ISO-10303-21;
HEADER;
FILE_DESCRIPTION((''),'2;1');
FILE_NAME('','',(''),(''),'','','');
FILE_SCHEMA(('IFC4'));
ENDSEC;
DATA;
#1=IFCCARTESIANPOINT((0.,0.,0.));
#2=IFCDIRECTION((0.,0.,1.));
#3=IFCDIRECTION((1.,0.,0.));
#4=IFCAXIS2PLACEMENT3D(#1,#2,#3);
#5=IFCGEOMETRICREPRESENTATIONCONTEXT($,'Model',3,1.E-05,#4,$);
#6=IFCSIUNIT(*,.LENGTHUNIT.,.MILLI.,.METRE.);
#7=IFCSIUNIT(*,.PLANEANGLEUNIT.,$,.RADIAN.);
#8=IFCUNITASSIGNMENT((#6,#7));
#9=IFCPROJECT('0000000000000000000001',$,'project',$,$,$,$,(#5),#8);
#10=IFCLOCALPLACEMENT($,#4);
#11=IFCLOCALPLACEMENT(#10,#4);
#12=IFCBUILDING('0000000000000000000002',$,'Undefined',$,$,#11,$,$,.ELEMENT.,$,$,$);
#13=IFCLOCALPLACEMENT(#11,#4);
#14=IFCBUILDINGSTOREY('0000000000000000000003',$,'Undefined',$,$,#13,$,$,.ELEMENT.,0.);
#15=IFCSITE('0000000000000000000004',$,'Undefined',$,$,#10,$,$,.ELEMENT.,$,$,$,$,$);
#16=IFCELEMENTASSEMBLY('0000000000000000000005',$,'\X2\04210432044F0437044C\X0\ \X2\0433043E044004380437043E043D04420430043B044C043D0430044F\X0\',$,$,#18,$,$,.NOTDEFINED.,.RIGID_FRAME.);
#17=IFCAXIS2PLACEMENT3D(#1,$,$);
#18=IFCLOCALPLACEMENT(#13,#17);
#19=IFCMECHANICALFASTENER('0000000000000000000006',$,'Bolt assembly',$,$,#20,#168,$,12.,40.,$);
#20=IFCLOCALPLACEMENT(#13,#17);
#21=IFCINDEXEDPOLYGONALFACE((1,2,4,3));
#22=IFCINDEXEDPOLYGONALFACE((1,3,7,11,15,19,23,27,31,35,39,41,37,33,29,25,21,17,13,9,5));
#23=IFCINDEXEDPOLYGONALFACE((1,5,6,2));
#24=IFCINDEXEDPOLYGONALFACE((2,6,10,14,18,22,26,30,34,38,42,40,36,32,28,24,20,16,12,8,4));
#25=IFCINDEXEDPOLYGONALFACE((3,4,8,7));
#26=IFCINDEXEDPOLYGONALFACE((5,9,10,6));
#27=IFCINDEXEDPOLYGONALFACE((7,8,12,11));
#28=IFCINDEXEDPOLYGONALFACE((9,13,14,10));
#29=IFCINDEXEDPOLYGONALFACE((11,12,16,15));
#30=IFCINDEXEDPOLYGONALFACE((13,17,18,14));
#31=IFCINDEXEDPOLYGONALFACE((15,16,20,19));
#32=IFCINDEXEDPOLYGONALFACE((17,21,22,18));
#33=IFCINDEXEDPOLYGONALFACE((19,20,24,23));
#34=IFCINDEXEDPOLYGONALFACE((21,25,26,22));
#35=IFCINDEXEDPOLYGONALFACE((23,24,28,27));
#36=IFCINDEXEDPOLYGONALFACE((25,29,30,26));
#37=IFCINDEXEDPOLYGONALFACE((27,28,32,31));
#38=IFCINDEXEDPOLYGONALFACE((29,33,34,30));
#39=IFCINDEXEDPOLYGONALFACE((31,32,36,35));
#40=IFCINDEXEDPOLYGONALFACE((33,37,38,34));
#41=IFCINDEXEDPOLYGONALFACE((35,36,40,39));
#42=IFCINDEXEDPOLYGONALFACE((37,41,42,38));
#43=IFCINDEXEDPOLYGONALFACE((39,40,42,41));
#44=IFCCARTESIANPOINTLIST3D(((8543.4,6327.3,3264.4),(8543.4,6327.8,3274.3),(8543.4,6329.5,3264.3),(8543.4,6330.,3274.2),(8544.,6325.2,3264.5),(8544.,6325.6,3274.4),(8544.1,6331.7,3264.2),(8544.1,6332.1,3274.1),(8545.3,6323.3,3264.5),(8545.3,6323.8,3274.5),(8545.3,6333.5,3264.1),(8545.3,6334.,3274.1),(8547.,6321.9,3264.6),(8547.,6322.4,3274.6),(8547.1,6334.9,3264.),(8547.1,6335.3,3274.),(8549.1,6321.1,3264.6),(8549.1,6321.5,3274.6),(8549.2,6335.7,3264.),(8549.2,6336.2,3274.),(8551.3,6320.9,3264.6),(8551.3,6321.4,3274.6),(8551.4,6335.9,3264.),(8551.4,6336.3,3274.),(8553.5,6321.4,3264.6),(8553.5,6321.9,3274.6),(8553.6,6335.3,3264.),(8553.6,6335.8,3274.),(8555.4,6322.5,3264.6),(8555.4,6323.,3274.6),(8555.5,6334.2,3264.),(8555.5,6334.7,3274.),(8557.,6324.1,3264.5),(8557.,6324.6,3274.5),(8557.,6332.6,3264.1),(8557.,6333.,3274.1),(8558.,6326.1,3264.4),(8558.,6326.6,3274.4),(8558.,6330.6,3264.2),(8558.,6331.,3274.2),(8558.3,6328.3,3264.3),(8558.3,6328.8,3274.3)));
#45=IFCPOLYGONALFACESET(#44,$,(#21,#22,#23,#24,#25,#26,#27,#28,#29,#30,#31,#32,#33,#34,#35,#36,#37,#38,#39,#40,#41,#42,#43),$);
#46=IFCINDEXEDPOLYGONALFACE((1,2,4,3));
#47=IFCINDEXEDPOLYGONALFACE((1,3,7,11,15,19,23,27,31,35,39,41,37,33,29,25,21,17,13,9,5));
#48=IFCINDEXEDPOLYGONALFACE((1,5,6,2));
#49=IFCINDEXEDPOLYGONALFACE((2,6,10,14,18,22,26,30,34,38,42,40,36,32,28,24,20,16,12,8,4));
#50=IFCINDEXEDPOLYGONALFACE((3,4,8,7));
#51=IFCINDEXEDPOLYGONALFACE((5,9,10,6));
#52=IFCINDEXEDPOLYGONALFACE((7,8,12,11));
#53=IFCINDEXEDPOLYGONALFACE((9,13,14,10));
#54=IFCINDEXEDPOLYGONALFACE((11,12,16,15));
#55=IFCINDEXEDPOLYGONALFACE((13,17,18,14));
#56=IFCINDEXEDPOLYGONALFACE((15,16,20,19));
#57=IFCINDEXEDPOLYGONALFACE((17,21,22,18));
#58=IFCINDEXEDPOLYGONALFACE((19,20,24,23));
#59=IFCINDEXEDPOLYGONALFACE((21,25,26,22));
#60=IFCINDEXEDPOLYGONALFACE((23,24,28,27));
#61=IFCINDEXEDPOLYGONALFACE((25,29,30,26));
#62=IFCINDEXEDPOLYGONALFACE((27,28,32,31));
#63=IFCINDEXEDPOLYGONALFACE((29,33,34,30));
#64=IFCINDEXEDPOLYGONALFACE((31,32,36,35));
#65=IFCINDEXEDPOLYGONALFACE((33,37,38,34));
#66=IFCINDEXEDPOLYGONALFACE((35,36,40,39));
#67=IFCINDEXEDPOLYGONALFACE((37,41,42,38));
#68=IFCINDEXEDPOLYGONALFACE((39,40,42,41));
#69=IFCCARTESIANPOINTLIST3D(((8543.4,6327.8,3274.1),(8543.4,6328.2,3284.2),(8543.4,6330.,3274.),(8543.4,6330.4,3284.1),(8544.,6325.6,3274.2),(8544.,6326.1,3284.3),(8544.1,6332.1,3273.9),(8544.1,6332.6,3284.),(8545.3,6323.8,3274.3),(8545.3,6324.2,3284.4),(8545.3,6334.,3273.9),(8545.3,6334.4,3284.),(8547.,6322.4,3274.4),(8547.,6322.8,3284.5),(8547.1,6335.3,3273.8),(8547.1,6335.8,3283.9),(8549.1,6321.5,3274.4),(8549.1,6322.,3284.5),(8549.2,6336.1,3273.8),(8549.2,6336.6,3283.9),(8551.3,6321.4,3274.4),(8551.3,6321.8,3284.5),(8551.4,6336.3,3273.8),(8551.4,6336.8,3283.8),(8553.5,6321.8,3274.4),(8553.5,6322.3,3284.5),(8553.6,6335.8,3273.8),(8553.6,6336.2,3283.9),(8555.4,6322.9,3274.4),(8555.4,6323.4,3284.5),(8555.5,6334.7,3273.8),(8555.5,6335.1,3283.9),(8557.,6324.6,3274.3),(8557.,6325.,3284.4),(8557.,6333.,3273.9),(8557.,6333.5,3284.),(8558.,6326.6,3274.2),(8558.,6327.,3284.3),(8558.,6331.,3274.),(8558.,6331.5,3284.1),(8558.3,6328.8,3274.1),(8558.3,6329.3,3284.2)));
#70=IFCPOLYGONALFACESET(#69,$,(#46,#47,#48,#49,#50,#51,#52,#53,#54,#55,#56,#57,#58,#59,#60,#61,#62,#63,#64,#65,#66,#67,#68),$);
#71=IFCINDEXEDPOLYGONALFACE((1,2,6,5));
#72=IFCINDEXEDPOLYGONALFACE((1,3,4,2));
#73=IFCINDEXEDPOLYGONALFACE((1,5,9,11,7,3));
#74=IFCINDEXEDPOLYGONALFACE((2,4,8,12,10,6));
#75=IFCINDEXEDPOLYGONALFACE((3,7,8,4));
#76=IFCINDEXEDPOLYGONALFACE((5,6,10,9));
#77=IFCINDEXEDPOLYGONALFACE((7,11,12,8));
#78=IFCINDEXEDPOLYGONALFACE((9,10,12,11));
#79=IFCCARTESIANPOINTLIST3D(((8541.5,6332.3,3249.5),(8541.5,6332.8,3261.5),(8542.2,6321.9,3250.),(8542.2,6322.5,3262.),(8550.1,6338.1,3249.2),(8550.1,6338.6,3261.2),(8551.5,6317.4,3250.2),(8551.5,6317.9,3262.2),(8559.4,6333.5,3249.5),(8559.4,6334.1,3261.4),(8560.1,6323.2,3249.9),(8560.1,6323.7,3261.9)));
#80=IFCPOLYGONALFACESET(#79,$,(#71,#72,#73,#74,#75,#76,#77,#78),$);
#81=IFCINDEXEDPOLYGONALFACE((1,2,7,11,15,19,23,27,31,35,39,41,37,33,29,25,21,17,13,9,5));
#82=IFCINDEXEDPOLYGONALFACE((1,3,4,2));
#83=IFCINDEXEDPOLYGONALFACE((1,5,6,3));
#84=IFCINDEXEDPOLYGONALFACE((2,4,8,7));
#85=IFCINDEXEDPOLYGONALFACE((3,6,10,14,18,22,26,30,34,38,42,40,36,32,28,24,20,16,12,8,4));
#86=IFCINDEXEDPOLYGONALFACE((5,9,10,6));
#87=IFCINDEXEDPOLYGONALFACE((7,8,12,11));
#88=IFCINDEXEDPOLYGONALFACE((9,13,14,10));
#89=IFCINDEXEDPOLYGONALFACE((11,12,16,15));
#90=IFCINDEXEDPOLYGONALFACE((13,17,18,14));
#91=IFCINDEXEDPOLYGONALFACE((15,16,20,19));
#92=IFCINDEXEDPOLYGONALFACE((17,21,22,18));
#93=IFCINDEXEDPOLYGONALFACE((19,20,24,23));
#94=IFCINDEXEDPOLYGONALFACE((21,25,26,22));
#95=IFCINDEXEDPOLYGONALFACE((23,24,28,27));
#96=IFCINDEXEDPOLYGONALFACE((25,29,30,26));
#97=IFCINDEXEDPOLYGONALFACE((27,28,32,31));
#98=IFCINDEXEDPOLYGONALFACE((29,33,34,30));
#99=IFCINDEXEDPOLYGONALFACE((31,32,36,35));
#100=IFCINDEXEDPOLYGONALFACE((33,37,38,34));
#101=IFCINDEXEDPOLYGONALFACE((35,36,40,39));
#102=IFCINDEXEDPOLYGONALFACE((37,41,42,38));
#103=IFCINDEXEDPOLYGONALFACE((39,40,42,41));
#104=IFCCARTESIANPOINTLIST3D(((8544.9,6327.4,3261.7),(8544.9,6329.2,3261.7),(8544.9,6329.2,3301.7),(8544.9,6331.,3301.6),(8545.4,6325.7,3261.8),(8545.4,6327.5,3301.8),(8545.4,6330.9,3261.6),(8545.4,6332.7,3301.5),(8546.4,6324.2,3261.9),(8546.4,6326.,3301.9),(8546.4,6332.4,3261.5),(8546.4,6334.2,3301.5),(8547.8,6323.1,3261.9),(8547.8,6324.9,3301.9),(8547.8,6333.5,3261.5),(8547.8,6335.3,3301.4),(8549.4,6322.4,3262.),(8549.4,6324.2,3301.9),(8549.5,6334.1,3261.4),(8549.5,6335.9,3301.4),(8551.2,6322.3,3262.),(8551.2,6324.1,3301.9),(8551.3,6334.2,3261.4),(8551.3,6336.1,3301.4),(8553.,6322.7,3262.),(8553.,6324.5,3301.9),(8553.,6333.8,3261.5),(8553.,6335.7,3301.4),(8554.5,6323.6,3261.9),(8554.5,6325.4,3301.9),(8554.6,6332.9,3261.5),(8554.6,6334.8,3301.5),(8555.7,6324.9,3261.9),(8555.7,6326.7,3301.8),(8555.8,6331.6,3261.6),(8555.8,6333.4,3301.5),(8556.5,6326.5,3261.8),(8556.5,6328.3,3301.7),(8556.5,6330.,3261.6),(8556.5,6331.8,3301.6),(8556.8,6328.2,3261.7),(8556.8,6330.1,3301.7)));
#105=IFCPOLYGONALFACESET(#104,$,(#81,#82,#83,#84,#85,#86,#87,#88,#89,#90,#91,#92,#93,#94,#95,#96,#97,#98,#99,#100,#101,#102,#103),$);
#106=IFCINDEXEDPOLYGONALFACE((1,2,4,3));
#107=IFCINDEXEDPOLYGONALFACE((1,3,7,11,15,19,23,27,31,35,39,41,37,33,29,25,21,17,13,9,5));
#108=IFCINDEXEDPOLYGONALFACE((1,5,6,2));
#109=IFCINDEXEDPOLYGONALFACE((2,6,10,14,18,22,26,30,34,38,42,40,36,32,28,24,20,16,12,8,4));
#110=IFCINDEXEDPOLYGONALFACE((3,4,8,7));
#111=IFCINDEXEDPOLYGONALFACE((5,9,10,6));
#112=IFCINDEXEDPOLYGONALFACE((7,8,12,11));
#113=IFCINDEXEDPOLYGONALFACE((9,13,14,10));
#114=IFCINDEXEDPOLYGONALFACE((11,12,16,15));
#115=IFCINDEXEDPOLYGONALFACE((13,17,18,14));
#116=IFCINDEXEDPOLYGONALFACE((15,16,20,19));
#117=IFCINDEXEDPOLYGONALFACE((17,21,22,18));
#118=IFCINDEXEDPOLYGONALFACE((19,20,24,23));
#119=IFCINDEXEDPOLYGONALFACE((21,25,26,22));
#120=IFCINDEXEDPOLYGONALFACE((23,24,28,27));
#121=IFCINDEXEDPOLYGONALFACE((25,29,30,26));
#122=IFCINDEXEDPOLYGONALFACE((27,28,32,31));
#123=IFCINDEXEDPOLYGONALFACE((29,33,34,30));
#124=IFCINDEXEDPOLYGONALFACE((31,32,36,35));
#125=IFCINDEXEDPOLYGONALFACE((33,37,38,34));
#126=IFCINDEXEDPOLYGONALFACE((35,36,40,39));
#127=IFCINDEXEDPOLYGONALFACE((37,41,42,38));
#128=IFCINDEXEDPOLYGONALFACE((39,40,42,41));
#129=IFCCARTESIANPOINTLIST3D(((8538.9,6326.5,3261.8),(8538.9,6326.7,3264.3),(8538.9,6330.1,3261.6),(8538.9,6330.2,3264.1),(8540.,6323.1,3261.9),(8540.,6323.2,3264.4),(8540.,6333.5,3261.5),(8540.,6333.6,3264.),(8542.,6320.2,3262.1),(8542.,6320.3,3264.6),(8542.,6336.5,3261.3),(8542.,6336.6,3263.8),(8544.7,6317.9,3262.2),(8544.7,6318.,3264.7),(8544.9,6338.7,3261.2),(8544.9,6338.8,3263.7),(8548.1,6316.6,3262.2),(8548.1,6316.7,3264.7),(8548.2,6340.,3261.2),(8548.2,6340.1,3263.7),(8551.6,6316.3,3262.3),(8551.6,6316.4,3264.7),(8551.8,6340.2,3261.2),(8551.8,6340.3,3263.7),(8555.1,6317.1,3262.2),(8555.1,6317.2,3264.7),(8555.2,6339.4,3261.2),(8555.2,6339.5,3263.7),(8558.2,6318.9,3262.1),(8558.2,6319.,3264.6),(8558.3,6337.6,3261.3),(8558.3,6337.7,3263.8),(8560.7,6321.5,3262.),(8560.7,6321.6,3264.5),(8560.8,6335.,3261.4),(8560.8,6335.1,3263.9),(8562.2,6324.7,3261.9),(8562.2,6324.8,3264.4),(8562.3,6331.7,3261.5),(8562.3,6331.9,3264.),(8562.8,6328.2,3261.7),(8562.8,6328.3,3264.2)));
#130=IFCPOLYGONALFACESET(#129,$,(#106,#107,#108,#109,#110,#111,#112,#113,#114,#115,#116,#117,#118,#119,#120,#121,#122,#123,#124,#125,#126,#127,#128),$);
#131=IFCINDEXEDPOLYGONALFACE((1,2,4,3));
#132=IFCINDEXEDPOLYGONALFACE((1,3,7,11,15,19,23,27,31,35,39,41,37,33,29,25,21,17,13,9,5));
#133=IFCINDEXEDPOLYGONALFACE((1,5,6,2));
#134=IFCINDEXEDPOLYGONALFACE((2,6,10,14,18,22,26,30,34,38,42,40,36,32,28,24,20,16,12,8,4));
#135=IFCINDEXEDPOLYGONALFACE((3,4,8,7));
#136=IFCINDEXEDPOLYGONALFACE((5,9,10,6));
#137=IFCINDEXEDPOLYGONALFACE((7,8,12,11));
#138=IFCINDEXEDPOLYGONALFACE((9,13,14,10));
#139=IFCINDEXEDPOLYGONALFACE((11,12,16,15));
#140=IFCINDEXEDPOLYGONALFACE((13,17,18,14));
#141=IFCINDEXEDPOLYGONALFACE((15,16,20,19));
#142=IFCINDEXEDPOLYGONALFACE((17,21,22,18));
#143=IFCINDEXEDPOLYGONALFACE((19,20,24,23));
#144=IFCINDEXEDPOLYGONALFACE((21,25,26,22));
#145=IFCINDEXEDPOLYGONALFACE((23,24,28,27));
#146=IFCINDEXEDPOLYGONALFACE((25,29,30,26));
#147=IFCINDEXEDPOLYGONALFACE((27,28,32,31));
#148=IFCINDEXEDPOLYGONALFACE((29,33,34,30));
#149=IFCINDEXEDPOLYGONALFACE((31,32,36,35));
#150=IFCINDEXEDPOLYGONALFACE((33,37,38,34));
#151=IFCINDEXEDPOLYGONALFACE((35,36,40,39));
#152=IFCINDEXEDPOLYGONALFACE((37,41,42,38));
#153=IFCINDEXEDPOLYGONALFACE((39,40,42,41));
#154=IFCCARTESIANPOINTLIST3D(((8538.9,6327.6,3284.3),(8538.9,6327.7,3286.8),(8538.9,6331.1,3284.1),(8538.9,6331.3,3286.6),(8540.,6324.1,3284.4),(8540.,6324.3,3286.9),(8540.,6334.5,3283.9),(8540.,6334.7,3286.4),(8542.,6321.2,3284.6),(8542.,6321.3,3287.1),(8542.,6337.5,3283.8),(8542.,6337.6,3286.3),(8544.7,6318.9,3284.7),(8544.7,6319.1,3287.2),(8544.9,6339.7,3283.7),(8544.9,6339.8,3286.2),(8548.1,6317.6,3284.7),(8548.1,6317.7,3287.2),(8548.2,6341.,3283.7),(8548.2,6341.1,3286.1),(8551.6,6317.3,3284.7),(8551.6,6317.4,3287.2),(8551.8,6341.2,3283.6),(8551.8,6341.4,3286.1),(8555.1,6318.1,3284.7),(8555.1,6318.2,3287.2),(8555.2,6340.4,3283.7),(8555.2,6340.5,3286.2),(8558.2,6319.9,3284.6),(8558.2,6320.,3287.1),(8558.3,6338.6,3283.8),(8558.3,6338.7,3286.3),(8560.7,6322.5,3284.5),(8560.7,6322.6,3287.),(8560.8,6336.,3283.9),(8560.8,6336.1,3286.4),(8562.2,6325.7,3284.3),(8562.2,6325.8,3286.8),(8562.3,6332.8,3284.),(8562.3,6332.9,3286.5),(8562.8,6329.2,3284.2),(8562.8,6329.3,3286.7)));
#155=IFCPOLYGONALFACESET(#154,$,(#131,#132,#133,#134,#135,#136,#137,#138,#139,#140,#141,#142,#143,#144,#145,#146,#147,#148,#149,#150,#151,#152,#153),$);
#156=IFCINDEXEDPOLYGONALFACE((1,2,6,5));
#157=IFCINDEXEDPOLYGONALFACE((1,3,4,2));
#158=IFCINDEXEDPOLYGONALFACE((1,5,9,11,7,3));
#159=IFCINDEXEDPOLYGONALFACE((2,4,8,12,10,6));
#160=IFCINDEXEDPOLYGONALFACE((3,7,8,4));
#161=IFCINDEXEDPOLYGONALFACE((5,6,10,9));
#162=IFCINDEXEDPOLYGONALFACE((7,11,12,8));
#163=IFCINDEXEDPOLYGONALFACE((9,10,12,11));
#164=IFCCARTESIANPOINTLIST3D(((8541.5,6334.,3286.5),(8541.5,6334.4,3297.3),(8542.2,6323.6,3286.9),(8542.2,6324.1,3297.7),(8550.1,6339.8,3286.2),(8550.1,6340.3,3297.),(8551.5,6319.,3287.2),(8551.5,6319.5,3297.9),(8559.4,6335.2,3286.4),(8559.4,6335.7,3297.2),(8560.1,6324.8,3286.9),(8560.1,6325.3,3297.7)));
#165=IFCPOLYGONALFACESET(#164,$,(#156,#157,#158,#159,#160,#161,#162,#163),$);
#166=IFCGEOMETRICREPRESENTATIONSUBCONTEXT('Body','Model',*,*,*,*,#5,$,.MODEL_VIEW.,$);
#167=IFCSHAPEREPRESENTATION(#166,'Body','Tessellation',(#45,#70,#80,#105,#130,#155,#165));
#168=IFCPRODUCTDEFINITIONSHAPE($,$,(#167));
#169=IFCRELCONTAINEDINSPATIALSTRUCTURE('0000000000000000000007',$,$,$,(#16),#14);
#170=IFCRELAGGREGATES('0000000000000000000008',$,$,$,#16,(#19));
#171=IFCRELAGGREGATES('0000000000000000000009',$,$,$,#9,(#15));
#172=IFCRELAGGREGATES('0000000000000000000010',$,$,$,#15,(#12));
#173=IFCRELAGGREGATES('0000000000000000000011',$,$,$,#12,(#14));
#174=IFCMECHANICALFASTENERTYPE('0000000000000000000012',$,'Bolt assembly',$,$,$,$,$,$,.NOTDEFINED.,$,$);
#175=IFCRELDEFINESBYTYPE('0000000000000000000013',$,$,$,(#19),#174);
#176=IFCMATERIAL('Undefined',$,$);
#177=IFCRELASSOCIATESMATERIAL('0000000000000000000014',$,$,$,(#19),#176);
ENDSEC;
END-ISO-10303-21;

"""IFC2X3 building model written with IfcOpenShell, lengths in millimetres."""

from ifc_helpers import new_model, si_unit, frame, origin_with_axes, origin_2d_with_axis, place, context, subcontext, project, spatial, polyline, circle, outline, extrude, source, transform, mapped, material, type_object, element, aggregate, save


model = new_model("IFC2X3")

# Units and contexts
model_context = context("Model", 3, precision=1e-05, world=origin_with_axes())
body_context = subcontext(model_context, "Body", "Model", "MODEL_VIEW")
ifc_project = project(units=[si_unit("LENGTHUNIT", "METRE", prefix="MILLI"), si_unit("PLANEANGLEUNIT", "RADIAN")], contexts=[model_context])

# Site, building, storey
site_placement = place(None, origin_with_axes())
site = spatial("IfcSite", under=ifc_project, at=site_placement, Name="Undefined", CompositionType="ELEMENT")
building_placement = place(site_placement, origin_with_axes())
building = spatial("IfcBuilding", under=site, at=building_placement, Name="Undefined", CompositionType="ELEMENT")
storey_placement = place(building_placement, origin_with_axes())
storey = spatial("IfcBuildingStorey", under=building, at=storey_placement, Name="Undefined", CompositionType="ELEMENT", Elevation=0.0)

# Element assembly
assembly_1_placement = place(storey_placement, origin_with_axes())
assembly_1 = element("IfcElementAssembly", 1, at=assembly_1_placement, inside=storey, Name="Связь горизонтальная", AssemblyPlace="NOTDEFINED", PredefinedType="RIGID_FRAME")

# Mechanical fastener
ifc_material_1 = material(Name="Undefined")
mechanical_fastener_type = type_object("IfcMechanicalFastenerType", Name="Bolt assembly")
shared_shape_1 = source(origin_with_axes(), body_context, "Body", "SweptSolid", [
    extrude(circle(Radius=7.5, at=origin_2d_with_axis()), frame((0.0, 0.1, 0.0), z_axis=(0.0, 1.0, 0.0), x_axis=(1.0, 0.0, 0.0)), (0.0, 0.0, 1.0), 10.0),
    extrude(circle(Radius=7.5, at=origin_2d_with_axis()), frame((0.0, 9.9, 0.0), z_axis=(0.0, 1.0, 0.0), x_axis=(1.0, 0.0, 0.0)), (0.0, 0.0, 1.0), 10.1),
    extrude(outline(polyline([(10.4, 0.0), (5.2, 9.0), (-5.2, 9.0), (-10.4, 0.0), (-5.2, -9.0), (5.2, -9.0), (10.4, 0.0)])), frame((0.0, -14.5, 0.0), z_axis=(0.0, 1.0, 0.0), x_axis=(1.0, 0.0, 0.0)), (0.0, 0.0, 1.0), 12.0),
    extrude(circle(Radius=6.0, at=origin_2d_with_axis()), frame((0.0, -2.5, 0.0), z_axis=(0.0, 1.0, 0.0), x_axis=(1.0, 0.0, 0.0)), (0.0, 0.0, 1.0), 40.0),
    extrude(circle(Radius=12.0, at=origin_2d_with_axis()), frame((0.0, -2.5, 0.0), z_axis=(0.0, 1.0, 0.0), x_axis=(1.0, 0.0, 0.0)), (0.0, 0.0, 1.0), 2.5),
    extrude(circle(Radius=12.0, at=origin_2d_with_axis()), frame((0.0, 20.0, 0.0), z_axis=(0.0, 1.0, 0.0), x_axis=(1.0, 0.0, 0.0)), (0.0, 0.0, 1.0), 2.5),
    extrude(outline(polyline([(10.4, 0.0), (5.2, 9.0), (-5.2, 9.0), (-10.4, 0.0), (-5.2, -9.0), (5.2, -9.0), (10.4, 0.0)])), frame((0.0, 22.5, 0.0), z_axis=(0.0, 1.0, 0.0), x_axis=(1.0, 0.0, 0.0)), (0.0, 0.0, 1.0), 10.8),
])
mechanical_fastener_1_placement = place(assembly_1_placement, frame((8550.8, 6328.4, 3264.2), z_axis=(0.558918, -0.828367, 0.037653), x_axis=(0.829223, 0.558342, -0.025379)))
mechanical_fastener_1 = element("IfcMechanicalFastener", 2, at=mechanical_fastener_1_placement, type_object=mechanical_fastener_type, material=ifc_material_1, Name="Bolt assembly", NominalDiameter=12.0, NominalLength=40.0, context=body_context, shape_type="MappedRepresentation", body=[
    mapped(shared_shape_1, transform((0.0, 0.0, 0.0))),
])
aggregate(assembly_1, [mechanical_fastener_1])

save(model, "model.ifc")
